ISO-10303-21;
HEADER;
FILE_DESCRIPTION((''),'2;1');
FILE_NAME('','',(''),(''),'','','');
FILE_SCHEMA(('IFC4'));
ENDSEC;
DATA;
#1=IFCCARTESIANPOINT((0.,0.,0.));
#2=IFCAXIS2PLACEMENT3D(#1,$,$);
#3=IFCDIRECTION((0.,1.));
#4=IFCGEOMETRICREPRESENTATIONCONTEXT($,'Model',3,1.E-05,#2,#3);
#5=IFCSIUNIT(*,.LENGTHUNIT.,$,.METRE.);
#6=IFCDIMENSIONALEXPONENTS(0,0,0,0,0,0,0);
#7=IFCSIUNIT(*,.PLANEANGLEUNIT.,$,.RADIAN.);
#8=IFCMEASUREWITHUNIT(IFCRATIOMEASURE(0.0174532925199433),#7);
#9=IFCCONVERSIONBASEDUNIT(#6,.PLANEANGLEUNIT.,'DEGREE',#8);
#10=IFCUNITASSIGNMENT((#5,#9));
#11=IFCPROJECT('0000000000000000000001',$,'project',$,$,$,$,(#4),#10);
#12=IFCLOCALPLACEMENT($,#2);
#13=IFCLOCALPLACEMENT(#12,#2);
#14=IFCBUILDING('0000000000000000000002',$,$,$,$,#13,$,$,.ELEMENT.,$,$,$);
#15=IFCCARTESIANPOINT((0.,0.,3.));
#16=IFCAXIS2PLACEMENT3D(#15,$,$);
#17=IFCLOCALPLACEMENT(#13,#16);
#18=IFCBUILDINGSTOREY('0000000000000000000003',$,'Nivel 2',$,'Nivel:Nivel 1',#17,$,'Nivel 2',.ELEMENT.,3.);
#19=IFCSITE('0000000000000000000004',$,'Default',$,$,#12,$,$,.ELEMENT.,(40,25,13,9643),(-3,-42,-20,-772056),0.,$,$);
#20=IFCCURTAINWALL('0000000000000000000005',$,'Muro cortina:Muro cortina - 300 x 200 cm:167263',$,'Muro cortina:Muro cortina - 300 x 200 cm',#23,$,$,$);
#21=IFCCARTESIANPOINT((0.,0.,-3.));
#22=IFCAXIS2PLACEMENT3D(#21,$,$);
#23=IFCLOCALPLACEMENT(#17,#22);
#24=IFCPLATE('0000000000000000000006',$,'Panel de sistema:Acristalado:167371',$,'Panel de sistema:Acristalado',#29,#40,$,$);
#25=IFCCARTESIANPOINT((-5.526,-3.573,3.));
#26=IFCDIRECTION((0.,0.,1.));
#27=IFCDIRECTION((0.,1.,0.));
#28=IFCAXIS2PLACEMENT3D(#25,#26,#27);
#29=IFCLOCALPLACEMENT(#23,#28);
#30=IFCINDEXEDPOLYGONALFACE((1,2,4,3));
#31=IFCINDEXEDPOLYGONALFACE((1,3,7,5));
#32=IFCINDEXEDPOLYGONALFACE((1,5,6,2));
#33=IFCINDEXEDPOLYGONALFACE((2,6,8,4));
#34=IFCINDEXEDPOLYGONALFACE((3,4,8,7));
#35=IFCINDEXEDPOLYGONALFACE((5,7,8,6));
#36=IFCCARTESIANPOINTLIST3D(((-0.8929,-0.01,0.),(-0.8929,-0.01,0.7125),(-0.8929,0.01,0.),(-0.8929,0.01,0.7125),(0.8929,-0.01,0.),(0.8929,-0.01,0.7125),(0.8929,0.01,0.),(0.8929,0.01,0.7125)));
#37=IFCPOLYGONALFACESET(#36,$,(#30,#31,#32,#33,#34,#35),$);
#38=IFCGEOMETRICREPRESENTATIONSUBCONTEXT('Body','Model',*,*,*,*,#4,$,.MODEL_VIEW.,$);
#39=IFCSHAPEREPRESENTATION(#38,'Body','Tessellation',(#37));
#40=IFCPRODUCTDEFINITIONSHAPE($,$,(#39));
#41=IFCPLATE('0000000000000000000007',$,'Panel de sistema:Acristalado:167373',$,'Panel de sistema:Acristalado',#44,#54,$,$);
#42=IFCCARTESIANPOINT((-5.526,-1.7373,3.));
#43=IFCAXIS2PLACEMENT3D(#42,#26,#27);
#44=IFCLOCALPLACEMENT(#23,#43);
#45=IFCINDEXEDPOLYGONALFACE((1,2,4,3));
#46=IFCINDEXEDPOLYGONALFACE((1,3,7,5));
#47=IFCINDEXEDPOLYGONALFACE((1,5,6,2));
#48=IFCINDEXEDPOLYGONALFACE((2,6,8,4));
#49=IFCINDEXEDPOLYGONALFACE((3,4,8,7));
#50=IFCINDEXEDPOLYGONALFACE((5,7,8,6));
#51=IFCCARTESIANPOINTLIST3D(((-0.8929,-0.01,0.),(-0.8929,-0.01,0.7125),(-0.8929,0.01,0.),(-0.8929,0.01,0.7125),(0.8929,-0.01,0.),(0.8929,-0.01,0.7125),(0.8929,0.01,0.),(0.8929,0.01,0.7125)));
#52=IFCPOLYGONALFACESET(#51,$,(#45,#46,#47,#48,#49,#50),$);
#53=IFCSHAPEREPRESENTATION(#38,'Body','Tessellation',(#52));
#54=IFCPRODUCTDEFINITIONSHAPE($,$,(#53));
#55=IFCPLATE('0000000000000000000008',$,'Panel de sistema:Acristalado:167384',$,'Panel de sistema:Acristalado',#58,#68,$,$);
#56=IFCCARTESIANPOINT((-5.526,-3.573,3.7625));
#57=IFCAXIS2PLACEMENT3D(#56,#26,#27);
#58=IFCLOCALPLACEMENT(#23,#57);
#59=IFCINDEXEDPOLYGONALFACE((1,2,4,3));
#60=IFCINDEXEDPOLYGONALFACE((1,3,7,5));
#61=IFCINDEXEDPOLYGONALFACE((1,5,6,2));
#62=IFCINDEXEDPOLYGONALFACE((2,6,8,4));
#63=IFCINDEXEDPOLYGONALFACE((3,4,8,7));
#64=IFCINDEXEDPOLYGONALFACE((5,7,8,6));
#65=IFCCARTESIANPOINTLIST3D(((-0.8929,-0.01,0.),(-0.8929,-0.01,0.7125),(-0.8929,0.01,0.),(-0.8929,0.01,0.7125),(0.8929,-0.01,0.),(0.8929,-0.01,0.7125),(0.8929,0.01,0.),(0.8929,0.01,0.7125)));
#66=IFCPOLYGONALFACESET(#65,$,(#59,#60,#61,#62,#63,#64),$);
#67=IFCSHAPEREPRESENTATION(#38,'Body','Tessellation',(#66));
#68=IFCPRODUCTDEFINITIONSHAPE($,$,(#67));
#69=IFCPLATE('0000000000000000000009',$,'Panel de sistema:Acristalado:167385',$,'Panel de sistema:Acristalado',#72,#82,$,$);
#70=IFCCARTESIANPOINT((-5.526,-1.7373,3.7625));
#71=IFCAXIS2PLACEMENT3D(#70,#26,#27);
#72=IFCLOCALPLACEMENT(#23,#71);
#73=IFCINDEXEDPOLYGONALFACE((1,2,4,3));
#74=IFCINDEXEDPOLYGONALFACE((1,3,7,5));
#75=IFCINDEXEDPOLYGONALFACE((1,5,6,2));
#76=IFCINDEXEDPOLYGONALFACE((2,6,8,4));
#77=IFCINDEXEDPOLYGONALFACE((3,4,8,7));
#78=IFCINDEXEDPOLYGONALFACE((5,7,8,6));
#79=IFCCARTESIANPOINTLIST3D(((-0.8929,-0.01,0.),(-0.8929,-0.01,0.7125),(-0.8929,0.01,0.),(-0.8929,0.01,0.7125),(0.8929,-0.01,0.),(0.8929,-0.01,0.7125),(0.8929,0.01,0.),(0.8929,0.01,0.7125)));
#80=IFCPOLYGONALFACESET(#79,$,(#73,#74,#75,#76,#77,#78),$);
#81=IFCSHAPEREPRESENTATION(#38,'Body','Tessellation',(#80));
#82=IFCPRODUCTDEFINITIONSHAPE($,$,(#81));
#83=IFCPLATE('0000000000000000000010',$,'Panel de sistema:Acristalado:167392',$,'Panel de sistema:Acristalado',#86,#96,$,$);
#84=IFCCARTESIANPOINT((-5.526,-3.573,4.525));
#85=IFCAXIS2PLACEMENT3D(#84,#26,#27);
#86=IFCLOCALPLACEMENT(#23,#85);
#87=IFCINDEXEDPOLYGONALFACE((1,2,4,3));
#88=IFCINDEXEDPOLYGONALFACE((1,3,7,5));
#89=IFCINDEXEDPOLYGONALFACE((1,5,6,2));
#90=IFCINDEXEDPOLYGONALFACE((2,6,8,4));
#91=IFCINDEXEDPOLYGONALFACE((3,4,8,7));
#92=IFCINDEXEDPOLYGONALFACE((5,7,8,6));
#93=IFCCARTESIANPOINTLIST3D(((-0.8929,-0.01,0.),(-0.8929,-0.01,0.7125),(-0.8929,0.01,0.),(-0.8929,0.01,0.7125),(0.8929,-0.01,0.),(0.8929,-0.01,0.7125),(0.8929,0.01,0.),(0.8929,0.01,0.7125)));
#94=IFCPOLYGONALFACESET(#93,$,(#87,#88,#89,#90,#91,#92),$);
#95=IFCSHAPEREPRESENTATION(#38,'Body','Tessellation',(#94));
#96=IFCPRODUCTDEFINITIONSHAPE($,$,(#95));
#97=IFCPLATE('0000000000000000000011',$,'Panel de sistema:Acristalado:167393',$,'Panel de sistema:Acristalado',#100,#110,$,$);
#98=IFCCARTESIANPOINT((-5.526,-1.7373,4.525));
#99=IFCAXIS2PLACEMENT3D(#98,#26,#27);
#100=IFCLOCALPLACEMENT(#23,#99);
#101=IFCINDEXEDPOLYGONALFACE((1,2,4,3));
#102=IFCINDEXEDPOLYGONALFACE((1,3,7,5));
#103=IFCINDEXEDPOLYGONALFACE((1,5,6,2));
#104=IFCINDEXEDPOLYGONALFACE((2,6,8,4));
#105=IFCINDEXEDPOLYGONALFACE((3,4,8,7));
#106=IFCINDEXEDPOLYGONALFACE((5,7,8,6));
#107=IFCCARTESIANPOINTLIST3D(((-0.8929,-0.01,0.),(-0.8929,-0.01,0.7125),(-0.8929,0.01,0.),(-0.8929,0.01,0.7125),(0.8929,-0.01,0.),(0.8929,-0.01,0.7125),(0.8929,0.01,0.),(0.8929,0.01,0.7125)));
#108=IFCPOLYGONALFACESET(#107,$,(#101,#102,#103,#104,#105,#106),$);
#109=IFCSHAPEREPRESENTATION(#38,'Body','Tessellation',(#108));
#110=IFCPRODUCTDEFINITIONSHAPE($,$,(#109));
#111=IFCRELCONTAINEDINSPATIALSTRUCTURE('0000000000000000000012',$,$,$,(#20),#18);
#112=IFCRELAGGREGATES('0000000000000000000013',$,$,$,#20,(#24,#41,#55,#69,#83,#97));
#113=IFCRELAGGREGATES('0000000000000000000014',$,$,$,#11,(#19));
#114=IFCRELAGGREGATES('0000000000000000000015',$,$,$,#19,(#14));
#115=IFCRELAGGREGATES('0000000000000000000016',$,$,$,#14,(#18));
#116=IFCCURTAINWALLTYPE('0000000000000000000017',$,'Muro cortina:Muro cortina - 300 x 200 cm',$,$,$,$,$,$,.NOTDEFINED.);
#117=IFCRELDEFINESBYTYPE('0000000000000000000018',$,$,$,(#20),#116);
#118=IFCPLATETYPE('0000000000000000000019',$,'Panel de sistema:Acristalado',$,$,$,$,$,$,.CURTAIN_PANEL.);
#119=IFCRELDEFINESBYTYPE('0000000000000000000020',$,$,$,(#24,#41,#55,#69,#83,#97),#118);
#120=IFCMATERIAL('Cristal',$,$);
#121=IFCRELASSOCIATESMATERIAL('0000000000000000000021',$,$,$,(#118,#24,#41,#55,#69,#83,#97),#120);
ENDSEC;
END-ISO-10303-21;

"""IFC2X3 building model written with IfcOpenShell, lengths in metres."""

from ifc_helpers import new_model, entity, si_unit, converted_unit, direction, frame, origin, origin_2d_with_axis, place, context, subcontext, project, spatial, rectangle, extrude, source, transform, mapped, material, type_object, type_shapes, element, aggregate, save


model = new_model("IFC2X3")

# Units and contexts
model_context = context("Model", 3, precision=1e-05, world=origin(), true_north=direction((0.0, 1.0)))
body_context = subcontext(model_context, "Body", "Model", "MODEL_VIEW")
ifc_project = project(units=[si_unit("LENGTHUNIT", "METRE"), converted_unit("PLANEANGLEUNIT", "DEGREE", entity("IfcRatioMeasure", 0.0174532925199433), si_unit("PLANEANGLEUNIT", "RADIAN"), dimensions=[0, 0, 0, 0, 0, 0, 0])], contexts=[model_context])

# Site, building, storey
site_placement = place(None, origin())
site = spatial("IfcSite", under=ifc_project, at=site_placement, Name="Default", CompositionType="ELEMENT", RefLatitude=(40, 25, 13, 9643), RefLongitude=(-3, -42, -20, -772056), RefElevation=0.0)
building_placement = place(site_placement, origin())
building = spatial("IfcBuilding", under=site, at=building_placement, CompositionType="ELEMENT")
storey_placement = place(building_placement, frame((0.0, 0.0, 3.0)))
storey = spatial("IfcBuildingStorey", under=building, at=storey_placement, Name="Nivel 2", ObjectType="Nivel:Nivel 1", LongName="Nivel 2", CompositionType="ELEMENT", Elevation=3.0)

# Curtain wall, plates
curtain_wall_type = type_object("IfcCurtainWallType", Name="Muro cortina:Muro cortina - 300 x 200 cm", PredefinedType="NOTDEFINED")
curtain_wall_placement = place(storey_placement, frame((0.0, 0.0, -3.0)))
curtain_wall = element("IfcCurtainWall", 1, at=curtain_wall_placement, inside=storey, type_object=curtain_wall_type, Name="Muro cortina:Muro cortina - 300 x 200 cm:167263", ObjectType="Muro cortina:Muro cortina - 300 x 200 cm")
ifc_material_1 = material(Name="Cristal")
plate_type = type_object("IfcPlateType", Name="Panel de sistema:Acristalado", PredefinedType="CURTAIN_PANEL", material=ifc_material_1)
shared_shape_1 = source(origin(), body_context, "Body", "SweptSolid", [
    extrude(rectangle(XDim=0.02, YDim=1.7857, at=origin_2d_with_axis()), frame((0.0, 0.0, 0.0), z_axis=(0.0, 0.0, 1.0), x_axis=(0.0, 1.0, 0.0)), (0.0, 0.0, 1.0), 0.7125),
])
type_shapes(plate_type, [shared_shape_1])
plate_1_placement = place(curtain_wall_placement, frame((-5.526, -3.573, 3.0), z_axis=(0.0, 0.0, 1.0), x_axis=(0.0, 1.0, 0.0)))
plate_1 = element("IfcPlate", 2, at=plate_1_placement, type_object=plate_type, material=ifc_material_1, Name="Panel de sistema:Acristalado:167371", ObjectType="Panel de sistema:Acristalado", context=body_context, shape_type="MappedRepresentation", body=[
    mapped(shared_shape_1, transform((0.0, 0.0, 0.0), scale=1.0)),
])
plate_2_placement = place(curtain_wall_placement, frame((-5.526, -1.7373, 3.0), z_axis=(0.0, 0.0, 1.0), x_axis=(0.0, 1.0, 0.0)))
plate_2 = element("IfcPlate", 3, at=plate_2_placement, type_object=plate_type, material=ifc_material_1, Name="Panel de sistema:Acristalado:167373", ObjectType="Panel de sistema:Acristalado", context=body_context, shape_type="MappedRepresentation", body=[
    mapped(shared_shape_1, transform((0.0, 0.0, 0.0), scale=1.0)),
])
plate_3_placement = place(curtain_wall_placement, frame((-5.526, -3.573, 3.7625), z_axis=(0.0, 0.0, 1.0), x_axis=(0.0, 1.0, 0.0)))
plate_3 = element("IfcPlate", 4, at=plate_3_placement, type_object=plate_type, material=ifc_material_1, Name="Panel de sistema:Acristalado:167384", ObjectType="Panel de sistema:Acristalado", context=body_context, shape_type="MappedRepresentation", body=[
    mapped(shared_shape_1, transform((0.0, 0.0, 0.0), scale=1.0)),
])
plate_4_placement = place(curtain_wall_placement, frame((-5.526, -1.7373, 3.7625), z_axis=(0.0, 0.0, 1.0), x_axis=(0.0, 1.0, 0.0)))
plate_4 = element("IfcPlate", 5, at=plate_4_placement, type_object=plate_type, material=ifc_material_1, Name="Panel de sistema:Acristalado:167385", ObjectType="Panel de sistema:Acristalado", context=body_context, shape_type="MappedRepresentation", body=[
    mapped(shared_shape_1, transform((0.0, 0.0, 0.0), scale=1.0)),
])
plate_5_placement = place(curtain_wall_placement, frame((-5.526, -3.573, 4.525), z_axis=(0.0, 0.0, 1.0), x_axis=(0.0, 1.0, 0.0)))
plate_5 = element("IfcPlate", 6, at=plate_5_placement, type_object=plate_type, material=ifc_material_1, Name="Panel de sistema:Acristalado:167392", ObjectType="Panel de sistema:Acristalado", context=body_context, shape_type="MappedRepresentation", body=[
    mapped(shared_shape_1, transform((0.0, 0.0, 0.0), scale=1.0)),
])
plate_6_placement = place(curtain_wall_placement, frame((-5.526, -1.7373, 4.525), z_axis=(0.0, 0.0, 1.0), x_axis=(0.0, 1.0, 0.0)))
plate_6 = element("IfcPlate", 7, at=plate_6_placement, type_object=plate_type, material=ifc_material_1, Name="Panel de sistema:Acristalado:167393", ObjectType="Panel de sistema:Acristalado", context=body_context, shape_type="MappedRepresentation", body=[
    mapped(shared_shape_1, transform((0.0, 0.0, 0.0), scale=1.0)),
])
aggregate(curtain_wall, [plate_1, plate_2, plate_3, plate_4, plate_5, plate_6])

save(model, "model.ifc")
